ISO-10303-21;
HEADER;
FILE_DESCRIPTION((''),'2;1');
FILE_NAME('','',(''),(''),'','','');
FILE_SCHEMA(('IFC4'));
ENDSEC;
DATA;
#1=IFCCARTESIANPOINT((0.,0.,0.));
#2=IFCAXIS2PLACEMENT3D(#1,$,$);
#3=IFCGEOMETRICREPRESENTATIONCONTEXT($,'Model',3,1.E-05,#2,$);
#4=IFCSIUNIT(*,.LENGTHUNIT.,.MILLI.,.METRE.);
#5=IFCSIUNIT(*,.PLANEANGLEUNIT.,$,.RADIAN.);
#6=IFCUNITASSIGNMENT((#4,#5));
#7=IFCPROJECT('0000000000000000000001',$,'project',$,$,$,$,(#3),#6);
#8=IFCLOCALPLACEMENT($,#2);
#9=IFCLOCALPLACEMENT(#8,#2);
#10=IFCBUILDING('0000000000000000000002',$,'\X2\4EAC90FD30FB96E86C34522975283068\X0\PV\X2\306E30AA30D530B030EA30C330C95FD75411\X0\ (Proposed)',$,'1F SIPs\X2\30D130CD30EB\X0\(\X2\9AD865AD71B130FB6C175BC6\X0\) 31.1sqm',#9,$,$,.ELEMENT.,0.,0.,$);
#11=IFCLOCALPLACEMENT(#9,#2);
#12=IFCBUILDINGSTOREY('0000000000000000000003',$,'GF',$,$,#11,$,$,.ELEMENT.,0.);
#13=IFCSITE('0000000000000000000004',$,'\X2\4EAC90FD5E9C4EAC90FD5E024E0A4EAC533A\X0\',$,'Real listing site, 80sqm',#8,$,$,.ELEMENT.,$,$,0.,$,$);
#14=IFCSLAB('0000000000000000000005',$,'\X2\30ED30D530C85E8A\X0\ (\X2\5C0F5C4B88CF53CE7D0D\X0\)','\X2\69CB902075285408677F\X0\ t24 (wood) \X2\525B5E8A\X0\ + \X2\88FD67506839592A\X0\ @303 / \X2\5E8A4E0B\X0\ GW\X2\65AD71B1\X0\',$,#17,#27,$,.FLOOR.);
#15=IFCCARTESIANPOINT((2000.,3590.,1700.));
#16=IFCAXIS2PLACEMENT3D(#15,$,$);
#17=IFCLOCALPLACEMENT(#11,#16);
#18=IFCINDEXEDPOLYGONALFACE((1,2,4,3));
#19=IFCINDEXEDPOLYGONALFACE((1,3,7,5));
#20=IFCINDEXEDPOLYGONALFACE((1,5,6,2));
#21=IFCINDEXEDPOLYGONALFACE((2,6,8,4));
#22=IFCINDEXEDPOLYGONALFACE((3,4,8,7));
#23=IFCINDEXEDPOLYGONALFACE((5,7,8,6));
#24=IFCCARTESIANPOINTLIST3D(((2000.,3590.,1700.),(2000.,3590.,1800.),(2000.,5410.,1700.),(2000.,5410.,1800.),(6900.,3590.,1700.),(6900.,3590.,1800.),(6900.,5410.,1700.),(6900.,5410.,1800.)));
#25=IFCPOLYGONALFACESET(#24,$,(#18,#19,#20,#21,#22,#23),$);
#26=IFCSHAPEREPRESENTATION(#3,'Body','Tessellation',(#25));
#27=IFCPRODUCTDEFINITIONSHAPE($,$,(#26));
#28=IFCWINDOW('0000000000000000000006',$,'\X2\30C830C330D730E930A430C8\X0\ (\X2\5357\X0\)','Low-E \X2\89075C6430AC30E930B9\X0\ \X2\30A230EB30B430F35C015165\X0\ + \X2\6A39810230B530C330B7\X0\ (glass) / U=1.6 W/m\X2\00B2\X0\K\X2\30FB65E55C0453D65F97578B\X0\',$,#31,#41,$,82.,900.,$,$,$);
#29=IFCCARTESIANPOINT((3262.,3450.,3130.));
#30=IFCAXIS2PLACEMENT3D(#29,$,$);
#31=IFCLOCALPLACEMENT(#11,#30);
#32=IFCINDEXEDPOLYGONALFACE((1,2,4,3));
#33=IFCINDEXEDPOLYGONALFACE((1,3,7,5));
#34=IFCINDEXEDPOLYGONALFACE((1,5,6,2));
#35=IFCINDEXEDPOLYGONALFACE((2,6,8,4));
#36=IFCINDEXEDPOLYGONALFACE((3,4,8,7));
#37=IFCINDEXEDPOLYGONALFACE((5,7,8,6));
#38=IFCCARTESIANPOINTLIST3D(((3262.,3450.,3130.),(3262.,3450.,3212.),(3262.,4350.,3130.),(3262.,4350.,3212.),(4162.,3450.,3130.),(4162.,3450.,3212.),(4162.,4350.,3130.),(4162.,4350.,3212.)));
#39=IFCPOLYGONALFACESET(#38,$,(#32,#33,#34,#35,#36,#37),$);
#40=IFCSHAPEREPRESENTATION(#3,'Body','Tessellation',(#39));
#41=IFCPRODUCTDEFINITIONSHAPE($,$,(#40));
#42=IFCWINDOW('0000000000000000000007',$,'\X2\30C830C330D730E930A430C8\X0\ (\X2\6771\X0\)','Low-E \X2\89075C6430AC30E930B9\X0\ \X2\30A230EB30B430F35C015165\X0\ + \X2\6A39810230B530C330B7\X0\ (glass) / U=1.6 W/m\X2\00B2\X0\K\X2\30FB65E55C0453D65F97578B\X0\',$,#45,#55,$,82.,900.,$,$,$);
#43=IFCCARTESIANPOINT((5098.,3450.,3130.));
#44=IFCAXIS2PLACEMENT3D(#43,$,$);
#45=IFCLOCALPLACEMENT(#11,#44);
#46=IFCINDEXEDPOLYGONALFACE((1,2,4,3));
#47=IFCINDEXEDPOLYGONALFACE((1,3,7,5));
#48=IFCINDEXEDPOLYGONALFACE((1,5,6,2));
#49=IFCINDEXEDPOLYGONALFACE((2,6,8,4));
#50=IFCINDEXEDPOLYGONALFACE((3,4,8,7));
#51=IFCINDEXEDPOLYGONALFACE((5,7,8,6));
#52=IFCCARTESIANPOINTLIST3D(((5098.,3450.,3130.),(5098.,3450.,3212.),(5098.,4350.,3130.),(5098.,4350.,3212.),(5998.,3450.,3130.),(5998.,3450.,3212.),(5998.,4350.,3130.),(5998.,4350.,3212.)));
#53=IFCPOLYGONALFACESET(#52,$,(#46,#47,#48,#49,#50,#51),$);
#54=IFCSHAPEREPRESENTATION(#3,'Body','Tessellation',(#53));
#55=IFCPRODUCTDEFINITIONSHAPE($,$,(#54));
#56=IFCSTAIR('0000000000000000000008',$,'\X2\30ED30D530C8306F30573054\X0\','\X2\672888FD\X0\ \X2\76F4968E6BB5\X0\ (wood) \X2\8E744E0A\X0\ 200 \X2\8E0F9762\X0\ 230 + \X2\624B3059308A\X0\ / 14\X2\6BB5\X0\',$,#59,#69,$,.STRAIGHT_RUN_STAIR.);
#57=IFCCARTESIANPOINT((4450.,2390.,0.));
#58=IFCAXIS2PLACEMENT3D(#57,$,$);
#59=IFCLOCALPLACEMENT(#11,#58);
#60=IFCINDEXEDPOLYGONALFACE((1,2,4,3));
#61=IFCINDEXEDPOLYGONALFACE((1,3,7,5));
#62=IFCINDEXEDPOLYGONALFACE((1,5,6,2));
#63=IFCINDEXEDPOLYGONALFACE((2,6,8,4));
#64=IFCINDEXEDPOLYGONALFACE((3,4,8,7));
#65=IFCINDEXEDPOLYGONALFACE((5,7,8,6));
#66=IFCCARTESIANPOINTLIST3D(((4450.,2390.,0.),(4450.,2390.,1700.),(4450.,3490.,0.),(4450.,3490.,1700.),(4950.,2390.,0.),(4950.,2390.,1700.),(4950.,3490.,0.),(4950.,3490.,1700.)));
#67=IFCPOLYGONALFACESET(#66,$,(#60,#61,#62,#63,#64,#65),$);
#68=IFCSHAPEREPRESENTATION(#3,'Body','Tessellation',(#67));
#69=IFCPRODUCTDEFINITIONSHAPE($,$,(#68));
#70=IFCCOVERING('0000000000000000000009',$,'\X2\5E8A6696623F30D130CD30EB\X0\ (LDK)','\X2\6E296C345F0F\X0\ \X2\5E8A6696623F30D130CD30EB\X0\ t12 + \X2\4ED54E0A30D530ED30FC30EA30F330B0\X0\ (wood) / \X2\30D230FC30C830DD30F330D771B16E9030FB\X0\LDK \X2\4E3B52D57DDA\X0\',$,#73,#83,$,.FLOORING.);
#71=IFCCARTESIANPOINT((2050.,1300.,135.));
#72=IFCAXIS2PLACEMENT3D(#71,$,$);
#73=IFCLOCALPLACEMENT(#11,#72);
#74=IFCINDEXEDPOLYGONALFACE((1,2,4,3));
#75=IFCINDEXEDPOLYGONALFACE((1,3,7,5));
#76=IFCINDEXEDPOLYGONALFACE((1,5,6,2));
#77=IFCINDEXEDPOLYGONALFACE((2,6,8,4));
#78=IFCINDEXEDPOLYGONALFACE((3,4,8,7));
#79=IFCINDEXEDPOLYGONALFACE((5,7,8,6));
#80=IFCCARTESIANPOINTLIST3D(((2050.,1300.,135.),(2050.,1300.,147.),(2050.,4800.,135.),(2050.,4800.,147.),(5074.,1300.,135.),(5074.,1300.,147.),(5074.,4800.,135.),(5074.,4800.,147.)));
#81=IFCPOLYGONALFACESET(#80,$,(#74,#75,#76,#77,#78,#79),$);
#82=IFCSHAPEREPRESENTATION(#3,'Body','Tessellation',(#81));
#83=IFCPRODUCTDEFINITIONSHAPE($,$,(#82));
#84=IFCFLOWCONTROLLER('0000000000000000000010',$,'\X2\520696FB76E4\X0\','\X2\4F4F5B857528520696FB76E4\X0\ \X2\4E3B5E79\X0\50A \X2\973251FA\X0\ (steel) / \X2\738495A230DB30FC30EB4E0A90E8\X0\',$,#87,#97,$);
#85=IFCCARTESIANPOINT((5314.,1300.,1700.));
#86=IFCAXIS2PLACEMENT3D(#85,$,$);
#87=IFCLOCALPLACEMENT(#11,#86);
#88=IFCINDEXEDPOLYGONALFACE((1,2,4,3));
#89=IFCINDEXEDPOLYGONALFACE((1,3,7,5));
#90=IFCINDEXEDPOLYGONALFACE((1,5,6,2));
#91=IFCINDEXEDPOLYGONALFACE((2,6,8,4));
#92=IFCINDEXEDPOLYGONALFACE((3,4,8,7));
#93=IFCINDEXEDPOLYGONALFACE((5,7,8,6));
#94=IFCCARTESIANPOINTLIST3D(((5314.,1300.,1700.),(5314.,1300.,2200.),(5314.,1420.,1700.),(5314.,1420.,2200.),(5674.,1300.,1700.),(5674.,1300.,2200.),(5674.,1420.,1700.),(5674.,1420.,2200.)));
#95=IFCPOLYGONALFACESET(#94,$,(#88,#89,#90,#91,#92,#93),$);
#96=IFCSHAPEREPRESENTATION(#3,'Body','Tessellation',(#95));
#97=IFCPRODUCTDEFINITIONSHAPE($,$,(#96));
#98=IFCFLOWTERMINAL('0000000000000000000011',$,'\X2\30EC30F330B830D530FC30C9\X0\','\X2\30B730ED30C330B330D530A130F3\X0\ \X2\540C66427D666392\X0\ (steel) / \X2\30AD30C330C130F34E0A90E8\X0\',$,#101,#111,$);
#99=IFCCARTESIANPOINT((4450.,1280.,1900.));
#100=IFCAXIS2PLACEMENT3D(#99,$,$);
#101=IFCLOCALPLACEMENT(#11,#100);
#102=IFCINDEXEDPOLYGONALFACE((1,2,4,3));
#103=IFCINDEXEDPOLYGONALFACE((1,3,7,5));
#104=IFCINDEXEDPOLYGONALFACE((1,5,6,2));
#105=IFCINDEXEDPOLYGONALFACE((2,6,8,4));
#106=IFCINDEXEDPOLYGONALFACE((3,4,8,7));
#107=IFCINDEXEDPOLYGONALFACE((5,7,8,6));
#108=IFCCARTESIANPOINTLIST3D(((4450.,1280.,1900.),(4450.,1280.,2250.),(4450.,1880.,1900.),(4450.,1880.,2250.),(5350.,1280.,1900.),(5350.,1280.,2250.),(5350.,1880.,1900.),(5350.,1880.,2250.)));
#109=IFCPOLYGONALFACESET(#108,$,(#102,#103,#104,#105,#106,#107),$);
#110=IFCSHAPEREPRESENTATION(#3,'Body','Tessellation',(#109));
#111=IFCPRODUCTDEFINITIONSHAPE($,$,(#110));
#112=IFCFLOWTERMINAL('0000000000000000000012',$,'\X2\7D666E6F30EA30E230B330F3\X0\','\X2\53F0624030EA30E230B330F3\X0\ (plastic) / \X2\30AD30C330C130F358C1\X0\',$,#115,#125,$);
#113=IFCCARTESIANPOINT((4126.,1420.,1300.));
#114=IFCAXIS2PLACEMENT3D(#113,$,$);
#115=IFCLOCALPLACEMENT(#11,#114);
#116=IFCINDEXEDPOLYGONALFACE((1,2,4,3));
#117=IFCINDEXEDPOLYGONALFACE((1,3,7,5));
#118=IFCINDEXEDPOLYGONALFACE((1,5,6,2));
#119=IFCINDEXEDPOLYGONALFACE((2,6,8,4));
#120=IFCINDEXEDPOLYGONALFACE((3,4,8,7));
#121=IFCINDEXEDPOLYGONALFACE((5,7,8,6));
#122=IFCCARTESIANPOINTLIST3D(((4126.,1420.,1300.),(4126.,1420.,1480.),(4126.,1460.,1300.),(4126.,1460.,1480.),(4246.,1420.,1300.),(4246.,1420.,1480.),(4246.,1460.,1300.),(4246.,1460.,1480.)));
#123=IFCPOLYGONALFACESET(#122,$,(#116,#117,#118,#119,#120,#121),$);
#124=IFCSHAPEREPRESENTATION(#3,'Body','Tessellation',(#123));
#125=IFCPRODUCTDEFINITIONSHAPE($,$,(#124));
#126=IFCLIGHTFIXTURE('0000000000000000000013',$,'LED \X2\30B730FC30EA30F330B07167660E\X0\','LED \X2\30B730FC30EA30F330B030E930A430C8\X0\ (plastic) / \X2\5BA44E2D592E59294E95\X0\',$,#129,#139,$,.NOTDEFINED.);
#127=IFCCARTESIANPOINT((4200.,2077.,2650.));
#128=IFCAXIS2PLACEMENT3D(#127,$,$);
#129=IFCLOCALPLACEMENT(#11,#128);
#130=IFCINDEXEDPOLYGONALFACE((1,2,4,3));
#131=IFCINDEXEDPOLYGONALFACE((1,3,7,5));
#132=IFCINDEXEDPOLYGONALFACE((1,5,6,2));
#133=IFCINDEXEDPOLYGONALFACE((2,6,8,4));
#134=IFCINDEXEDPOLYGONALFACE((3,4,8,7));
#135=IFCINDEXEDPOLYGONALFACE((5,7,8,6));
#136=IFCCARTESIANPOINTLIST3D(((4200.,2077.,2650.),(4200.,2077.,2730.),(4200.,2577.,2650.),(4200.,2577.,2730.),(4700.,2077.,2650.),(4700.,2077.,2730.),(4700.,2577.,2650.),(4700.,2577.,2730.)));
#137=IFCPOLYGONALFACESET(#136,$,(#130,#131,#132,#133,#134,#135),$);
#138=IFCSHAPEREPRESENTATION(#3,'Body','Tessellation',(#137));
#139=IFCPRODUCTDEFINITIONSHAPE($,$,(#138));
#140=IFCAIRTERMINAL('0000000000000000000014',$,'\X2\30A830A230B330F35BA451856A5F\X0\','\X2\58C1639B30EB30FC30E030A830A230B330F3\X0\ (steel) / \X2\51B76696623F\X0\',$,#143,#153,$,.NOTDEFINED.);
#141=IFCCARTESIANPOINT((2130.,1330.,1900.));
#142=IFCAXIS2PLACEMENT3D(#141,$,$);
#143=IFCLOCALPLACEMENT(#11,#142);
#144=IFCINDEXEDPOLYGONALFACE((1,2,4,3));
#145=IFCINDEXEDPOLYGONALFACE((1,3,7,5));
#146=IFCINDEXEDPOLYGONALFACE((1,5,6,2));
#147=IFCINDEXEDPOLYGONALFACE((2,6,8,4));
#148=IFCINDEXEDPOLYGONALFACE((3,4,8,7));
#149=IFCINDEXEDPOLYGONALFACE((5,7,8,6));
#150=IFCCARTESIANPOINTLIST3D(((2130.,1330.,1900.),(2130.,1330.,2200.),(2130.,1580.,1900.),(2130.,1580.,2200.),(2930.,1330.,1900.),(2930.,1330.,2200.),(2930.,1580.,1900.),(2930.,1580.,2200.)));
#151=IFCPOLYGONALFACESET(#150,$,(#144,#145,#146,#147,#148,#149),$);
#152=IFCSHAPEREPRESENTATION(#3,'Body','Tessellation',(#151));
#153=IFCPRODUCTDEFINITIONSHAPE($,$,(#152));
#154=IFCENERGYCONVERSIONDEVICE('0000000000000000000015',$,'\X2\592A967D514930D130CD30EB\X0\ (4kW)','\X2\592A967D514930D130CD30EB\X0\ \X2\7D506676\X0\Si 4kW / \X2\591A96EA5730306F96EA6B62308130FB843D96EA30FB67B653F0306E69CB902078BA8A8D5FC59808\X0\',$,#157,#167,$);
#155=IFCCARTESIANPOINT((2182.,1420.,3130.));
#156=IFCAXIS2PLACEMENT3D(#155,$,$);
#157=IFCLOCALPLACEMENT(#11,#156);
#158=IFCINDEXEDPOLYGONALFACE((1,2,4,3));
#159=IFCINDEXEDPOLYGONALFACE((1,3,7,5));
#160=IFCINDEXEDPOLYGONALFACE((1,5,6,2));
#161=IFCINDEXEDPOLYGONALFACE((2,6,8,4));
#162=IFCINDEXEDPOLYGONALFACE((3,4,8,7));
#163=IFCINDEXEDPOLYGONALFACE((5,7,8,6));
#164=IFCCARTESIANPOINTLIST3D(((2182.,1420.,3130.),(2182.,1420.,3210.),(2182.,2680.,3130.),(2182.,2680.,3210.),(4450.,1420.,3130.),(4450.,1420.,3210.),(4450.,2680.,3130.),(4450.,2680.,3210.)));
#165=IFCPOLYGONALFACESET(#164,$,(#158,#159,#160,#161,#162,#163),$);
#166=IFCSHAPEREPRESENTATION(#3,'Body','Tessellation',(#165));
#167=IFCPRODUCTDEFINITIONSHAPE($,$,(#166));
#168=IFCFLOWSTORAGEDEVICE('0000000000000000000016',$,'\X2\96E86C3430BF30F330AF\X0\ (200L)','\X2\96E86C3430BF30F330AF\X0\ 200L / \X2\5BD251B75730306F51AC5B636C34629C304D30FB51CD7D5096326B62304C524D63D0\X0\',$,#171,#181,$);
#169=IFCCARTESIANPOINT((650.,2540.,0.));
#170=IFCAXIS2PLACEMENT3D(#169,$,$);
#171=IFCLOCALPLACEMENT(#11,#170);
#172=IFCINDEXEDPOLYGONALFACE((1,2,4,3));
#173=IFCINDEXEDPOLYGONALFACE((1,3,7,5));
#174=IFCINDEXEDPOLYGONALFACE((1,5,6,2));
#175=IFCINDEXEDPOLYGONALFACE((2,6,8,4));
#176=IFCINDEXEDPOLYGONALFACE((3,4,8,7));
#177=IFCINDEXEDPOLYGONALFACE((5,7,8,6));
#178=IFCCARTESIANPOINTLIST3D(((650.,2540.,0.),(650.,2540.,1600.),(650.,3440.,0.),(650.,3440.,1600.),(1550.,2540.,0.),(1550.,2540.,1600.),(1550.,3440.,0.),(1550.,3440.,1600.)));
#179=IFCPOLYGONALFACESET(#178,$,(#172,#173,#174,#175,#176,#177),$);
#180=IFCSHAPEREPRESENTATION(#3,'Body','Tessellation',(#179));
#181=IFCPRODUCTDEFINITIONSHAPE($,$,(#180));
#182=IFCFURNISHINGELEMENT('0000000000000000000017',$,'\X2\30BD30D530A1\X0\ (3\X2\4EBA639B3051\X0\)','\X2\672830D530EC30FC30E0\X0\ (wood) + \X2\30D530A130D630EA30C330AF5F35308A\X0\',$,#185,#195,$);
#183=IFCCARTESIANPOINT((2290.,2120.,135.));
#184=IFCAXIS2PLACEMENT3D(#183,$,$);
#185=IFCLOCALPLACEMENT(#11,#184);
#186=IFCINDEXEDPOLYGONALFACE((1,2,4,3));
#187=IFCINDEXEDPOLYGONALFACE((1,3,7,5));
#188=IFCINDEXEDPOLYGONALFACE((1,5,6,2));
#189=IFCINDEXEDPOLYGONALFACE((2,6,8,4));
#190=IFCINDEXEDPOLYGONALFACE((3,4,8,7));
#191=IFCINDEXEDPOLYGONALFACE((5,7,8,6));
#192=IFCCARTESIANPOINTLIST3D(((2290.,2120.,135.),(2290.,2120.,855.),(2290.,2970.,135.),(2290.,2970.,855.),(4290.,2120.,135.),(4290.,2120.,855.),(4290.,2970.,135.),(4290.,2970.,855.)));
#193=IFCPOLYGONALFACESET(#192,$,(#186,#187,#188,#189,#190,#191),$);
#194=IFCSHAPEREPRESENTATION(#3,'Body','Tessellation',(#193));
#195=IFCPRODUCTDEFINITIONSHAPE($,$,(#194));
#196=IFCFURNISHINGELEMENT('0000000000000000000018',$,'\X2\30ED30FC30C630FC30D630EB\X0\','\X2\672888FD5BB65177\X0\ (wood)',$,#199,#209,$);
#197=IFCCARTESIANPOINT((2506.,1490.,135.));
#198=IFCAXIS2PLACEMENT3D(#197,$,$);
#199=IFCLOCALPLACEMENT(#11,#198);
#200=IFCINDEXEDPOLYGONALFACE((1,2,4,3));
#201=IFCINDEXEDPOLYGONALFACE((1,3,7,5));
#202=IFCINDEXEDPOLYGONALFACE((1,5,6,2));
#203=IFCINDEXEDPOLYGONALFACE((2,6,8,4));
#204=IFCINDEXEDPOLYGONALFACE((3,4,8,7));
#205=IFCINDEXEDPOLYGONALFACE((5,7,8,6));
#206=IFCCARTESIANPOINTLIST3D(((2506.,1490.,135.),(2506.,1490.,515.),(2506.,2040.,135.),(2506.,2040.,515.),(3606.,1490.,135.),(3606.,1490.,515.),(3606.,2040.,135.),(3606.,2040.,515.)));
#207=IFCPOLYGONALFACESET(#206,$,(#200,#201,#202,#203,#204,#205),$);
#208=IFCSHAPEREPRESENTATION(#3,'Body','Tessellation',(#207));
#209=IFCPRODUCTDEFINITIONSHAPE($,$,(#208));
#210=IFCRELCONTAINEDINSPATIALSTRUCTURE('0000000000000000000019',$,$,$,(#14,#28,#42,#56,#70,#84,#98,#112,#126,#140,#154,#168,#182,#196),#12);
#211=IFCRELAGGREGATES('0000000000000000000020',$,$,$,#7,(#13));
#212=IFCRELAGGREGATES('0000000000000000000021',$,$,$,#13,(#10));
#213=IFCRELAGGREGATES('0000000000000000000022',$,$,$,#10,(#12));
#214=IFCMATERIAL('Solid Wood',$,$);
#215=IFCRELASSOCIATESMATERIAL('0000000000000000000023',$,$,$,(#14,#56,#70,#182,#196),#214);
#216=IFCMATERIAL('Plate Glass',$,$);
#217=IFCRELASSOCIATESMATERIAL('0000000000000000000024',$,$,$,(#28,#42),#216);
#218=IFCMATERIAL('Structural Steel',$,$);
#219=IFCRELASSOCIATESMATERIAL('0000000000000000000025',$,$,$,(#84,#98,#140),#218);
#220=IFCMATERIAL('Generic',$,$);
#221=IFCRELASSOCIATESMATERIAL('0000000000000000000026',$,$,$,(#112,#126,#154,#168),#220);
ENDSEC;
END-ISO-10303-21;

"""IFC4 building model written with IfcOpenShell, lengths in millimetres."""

from ifc_helpers import new_model, si_unit, frame, frame_2d, origin, place, context, project, spatial, rectangle, extrude, material, element, save


model = new_model("IFC4")

# Units and contexts
model_context = context("Model", 3, precision=1e-05, world=origin())
ifc_project = project(units=[si_unit("LENGTHUNIT", "METRE", prefix="MILLI"), si_unit("PLANEANGLEUNIT", "RADIAN")], contexts=[model_context])

# Site, building, storey
site_placement = place(None, origin())
site = spatial("IfcSite", under=ifc_project, at=site_placement, Name="京都府京都市上京区", ObjectType="Real listing site, 80sqm", CompositionType="ELEMENT", RefElevation=0.0)
building_placement = place(site_placement, origin())
building = spatial("IfcBuilding", under=site, at=building_placement, Name="京都・雨水利用とPVのオフグリッド志向 (Proposed)", ObjectType="1F SIPsパネル(高断熱・気密) 31.1sqm", CompositionType="ELEMENT", ElevationOfRefHeight=0.0, ElevationOfTerrain=0.0)
storey_placement = place(building_placement, origin())
storey = spatial("IfcBuildingStorey", under=building, at=storey_placement, Name="GF", CompositionType="ELEMENT", Elevation=0.0)

# Shared definitions
ifc_material_1 = material(Name="Solid Wood")

# Slab
slab_placement = place(storey_placement, frame((2000.0, 3590.0, 1700.0)))
element("IfcSlab", 1, at=slab_placement, inside=storey, material=ifc_material_1, Name="ロフト床 (小屋裏収納)", Description="構造用合板 t24 (wood) 剛床 + 製材根太 @303 / 床下 GW断熱", PredefinedType="FLOOR", context=model_context, shape_type="SweptSolid", body=[
    extrude(rectangle(XDim=4900.0, YDim=1820.0, at=frame_2d((2450.0, 910.0))), frame((2000.0, 3590.0, 1700.0)), (0.0, 0.0, 1.0), 100.0),
])

# Windows
ifc_material_2 = material(Name="Plate Glass")
window_1_placement = place(storey_placement, frame((3262.0, 3450.0, 3130.0)))
element("IfcWindow", 2, at=window_1_placement, inside=storey, material=ifc_material_2, Name="トップライト (南)", Description="Low-E 複層ガラス アルゴン封入 + 樹脂サッシ (glass) / U=1.6 W/m²K・日射取得型", OverallHeight=82.0, OverallWidth=900.0, context=model_context, shape_type="SweptSolid", body=[
    extrude(rectangle(XDim=900.0, YDim=900.0, at=frame_2d((450.0, 450.0))), frame((3262.0, 3450.0, 3130.0)), (0.0, 0.0, 1.0), 82.0),
])
window_2_placement = place(storey_placement, frame((5098.0, 3450.0, 3130.0)))
element("IfcWindow", 3, at=window_2_placement, inside=storey, material=ifc_material_2, Name="トップライト (東)", Description="Low-E 複層ガラス アルゴン封入 + 樹脂サッシ (glass) / U=1.6 W/m²K・日射取得型", OverallHeight=82.0, OverallWidth=900.0, context=model_context, shape_type="SweptSolid", body=[
    extrude(rectangle(XDim=900.0, YDim=900.0, at=frame_2d((450.0, 450.0))), frame((5098.0, 3450.0, 3130.0)), (0.0, 0.0, 1.0), 82.0),
])

# Stair
stair_placement = place(storey_placement, frame((4450.0, 2390.0, 0.0)))
element("IfcStair", 4, at=stair_placement, inside=storey, material=ifc_material_1, Name="ロフトはしご", Description="木製 直階段 (wood) 蹴上 200 踏面 230 + 手すり / 14段", PredefinedType="STRAIGHT_RUN_STAIR", context=model_context, shape_type="SweptSolid", body=[
    extrude(rectangle(XDim=500.0, YDim=1100.0, at=frame_2d((250.0, 550.0))), frame((4450.0, 2390.0, 0.0)), (0.0, 0.0, 1.0), 1700.0),
])

# Covering
covering_placement = place(storey_placement, frame((2050.0, 1300.0, 135.0)))
element("IfcCovering", 5, at=covering_placement, inside=storey, material=ifc_material_1, Name="床暖房パネル (LDK)", Description="温水式 床暖房パネル t12 + 仕上フローリング (wood) / ヒートポンプ熱源・LDK 主動線", PredefinedType="FLOORING", context=model_context, shape_type="SweptSolid", body=[
    extrude(rectangle(XDim=3024.0, YDim=3500.0, at=frame_2d((1512.0, 1750.0))), frame((2050.0, 1300.0, 135.0)), (0.0, 0.0, 1.0), 12.0),
])

# Flow controller
ifc_material_3 = material(Name="Structural Steel")
flow_controller_placement = place(storey_placement, frame((5314.0, 1300.0, 1700.0)))
element("IfcFlowController", 6, at=flow_controller_placement, inside=storey, material=ifc_material_3, Name="分電盤", Description="住宅用分電盤 主幹50A 露出 (steel) / 玄関ホール上部", context=model_context, shape_type="SweptSolid", body=[
    extrude(rectangle(XDim=360.0, YDim=120.0, at=frame_2d((180.0, 60.0))), frame((5314.0, 1300.0, 1700.0)), (0.0, 0.0, 1.0), 500.0),
])

# Flow terminals
flow_terminal_1_placement = place(storey_placement, frame((4450.0, 1280.0, 1900.0)))
element("IfcFlowTerminal", 7, at=flow_terminal_1_placement, inside=storey, material=ifc_material_3, Name="レンジフード", Description="シロッコファン 同時給排 (steel) / キッチン上部", context=model_context, shape_type="SweptSolid", body=[
    extrude(rectangle(XDim=900.0, YDim=600.0, at=frame_2d((450.0, 300.0))), frame((4450.0, 1280.0, 1900.0)), (0.0, 0.0, 1.0), 350.0),
])
ifc_material_4 = material(Name="Generic")
flow_terminal_2_placement = place(storey_placement, frame((4126.0, 1420.0, 1300.0)))
element("IfcFlowTerminal", 8, at=flow_terminal_2_placement, inside=storey, material=ifc_material_4, Name="給湯リモコン", Description="台所リモコン (plastic) / キッチン壁", context=model_context, shape_type="SweptSolid", body=[
    extrude(rectangle(XDim=120.0, YDim=40.0, at=frame_2d((60.0, 20.0))), frame((4126.0, 1420.0, 1300.0)), (0.0, 0.0, 1.0), 180.0),
])

# Light fixture
light_fixture_placement = place(storey_placement, frame((4200.0, 2077.0, 2650.0)))
element("IfcLightFixture", 9, at=light_fixture_placement, inside=storey, material=ifc_material_4, Name="LED シーリング照明", Description="LED シーリングライト (plastic) / 室中央天井", PredefinedType="NOTDEFINED", context=model_context, shape_type="SweptSolid", body=[
    extrude(rectangle(XDim=500.0, YDim=500.0, at=frame_2d((250.0, 250.0))), frame((4200.0, 2077.0, 2650.0)), (0.0, 0.0, 1.0), 80.0),
])

# Air terminal
air_terminal_placement = place(storey_placement, frame((2130.0, 1330.0, 1900.0)))
element("IfcAirTerminal", 10, at=air_terminal_placement, inside=storey, material=ifc_material_3, Name="エアコン室内機", Description="壁掛ルームエアコン (steel) / 冷暖房", PredefinedType="NOTDEFINED", context=model_context, shape_type="SweptSolid", body=[
    extrude(rectangle(XDim=800.0, YDim=250.0, at=frame_2d((400.0, 125.0))), frame((2130.0, 1330.0, 1900.0)), (0.0, 0.0, 1.0), 300.0),
])

# Energy conversion device
energy_conversion_device_placement = place(storey_placement, frame((2182.0, 1420.0, 3130.0)))
element("IfcEnergyConversionDevice", 11, at=energy_conversion_device_placement, inside=storey, material=ifc_material_4, Name="太陽光パネル (4kW)", Description="太陽光パネル 結晶Si 4kW / 多雪地は雪止め・落雪・架台の構造確認必須", context=model_context, shape_type="SweptSolid", body=[
    extrude(rectangle(XDim=2268.0, YDim=1260.0, at=frame_2d((1134.0, 630.0))), frame((2182.0, 1420.0, 3130.0)), (0.0, 0.0, 1.0), 80.0),
])

# Flow storage device
flow_storage_device_placement = place(storey_placement, frame((650.0, 2540.0, 0.0)))
element("IfcFlowStorageDevice", 12, at=flow_storage_device_placement, inside=storey, material=ifc_material_4, Name="雨水タンク (200L)", Description="雨水タンク 200L / 寒冷地は冬季水抜き・凍結防止が前提", context=model_context, shape_type="SweptSolid", body=[
    extrude(rectangle(XDim=900.0, YDim=900.0, at=frame_2d((450.0, 450.0))), frame((650.0, 2540.0, 0.0)), (0.0, 0.0, 1.0), 1600.0),
])

# Furnishing elements
furnishing_1_placement = place(storey_placement, frame((2290.0, 2120.0, 135.0)))
element("IfcFurnishingElement", 13, at=furnishing_1_placement, inside=storey, material=ifc_material_1, Name="ソファ (3人掛け)", Description="木フレーム (wood) + ファブリック張り", context=model_context, shape_type="SweptSolid", body=[
    extrude(rectangle(XDim=2000.0, YDim=850.0, at=frame_2d((1000.0, 425.0))), frame((2290.0, 2120.0, 135.0)), (0.0, 0.0, 1.0), 720.0),
])
furnishing_2_placement = place(storey_placement, frame((2506.0, 1490.0, 135.0)))
element("IfcFurnishingElement", 14, at=furnishing_2_placement, inside=storey, material=ifc_material_1, Name="ローテーブル", Description="木製家具 (wood)", context=model_context, shape_type="SweptSolid", body=[
    extrude(rectangle(XDim=1100.0, YDim=550.0, at=frame_2d((550.0, 275.0))), frame((2506.0, 1490.0, 135.0)), (0.0, 0.0, 1.0), 380.0),
])

save(model, "model.ifc")
